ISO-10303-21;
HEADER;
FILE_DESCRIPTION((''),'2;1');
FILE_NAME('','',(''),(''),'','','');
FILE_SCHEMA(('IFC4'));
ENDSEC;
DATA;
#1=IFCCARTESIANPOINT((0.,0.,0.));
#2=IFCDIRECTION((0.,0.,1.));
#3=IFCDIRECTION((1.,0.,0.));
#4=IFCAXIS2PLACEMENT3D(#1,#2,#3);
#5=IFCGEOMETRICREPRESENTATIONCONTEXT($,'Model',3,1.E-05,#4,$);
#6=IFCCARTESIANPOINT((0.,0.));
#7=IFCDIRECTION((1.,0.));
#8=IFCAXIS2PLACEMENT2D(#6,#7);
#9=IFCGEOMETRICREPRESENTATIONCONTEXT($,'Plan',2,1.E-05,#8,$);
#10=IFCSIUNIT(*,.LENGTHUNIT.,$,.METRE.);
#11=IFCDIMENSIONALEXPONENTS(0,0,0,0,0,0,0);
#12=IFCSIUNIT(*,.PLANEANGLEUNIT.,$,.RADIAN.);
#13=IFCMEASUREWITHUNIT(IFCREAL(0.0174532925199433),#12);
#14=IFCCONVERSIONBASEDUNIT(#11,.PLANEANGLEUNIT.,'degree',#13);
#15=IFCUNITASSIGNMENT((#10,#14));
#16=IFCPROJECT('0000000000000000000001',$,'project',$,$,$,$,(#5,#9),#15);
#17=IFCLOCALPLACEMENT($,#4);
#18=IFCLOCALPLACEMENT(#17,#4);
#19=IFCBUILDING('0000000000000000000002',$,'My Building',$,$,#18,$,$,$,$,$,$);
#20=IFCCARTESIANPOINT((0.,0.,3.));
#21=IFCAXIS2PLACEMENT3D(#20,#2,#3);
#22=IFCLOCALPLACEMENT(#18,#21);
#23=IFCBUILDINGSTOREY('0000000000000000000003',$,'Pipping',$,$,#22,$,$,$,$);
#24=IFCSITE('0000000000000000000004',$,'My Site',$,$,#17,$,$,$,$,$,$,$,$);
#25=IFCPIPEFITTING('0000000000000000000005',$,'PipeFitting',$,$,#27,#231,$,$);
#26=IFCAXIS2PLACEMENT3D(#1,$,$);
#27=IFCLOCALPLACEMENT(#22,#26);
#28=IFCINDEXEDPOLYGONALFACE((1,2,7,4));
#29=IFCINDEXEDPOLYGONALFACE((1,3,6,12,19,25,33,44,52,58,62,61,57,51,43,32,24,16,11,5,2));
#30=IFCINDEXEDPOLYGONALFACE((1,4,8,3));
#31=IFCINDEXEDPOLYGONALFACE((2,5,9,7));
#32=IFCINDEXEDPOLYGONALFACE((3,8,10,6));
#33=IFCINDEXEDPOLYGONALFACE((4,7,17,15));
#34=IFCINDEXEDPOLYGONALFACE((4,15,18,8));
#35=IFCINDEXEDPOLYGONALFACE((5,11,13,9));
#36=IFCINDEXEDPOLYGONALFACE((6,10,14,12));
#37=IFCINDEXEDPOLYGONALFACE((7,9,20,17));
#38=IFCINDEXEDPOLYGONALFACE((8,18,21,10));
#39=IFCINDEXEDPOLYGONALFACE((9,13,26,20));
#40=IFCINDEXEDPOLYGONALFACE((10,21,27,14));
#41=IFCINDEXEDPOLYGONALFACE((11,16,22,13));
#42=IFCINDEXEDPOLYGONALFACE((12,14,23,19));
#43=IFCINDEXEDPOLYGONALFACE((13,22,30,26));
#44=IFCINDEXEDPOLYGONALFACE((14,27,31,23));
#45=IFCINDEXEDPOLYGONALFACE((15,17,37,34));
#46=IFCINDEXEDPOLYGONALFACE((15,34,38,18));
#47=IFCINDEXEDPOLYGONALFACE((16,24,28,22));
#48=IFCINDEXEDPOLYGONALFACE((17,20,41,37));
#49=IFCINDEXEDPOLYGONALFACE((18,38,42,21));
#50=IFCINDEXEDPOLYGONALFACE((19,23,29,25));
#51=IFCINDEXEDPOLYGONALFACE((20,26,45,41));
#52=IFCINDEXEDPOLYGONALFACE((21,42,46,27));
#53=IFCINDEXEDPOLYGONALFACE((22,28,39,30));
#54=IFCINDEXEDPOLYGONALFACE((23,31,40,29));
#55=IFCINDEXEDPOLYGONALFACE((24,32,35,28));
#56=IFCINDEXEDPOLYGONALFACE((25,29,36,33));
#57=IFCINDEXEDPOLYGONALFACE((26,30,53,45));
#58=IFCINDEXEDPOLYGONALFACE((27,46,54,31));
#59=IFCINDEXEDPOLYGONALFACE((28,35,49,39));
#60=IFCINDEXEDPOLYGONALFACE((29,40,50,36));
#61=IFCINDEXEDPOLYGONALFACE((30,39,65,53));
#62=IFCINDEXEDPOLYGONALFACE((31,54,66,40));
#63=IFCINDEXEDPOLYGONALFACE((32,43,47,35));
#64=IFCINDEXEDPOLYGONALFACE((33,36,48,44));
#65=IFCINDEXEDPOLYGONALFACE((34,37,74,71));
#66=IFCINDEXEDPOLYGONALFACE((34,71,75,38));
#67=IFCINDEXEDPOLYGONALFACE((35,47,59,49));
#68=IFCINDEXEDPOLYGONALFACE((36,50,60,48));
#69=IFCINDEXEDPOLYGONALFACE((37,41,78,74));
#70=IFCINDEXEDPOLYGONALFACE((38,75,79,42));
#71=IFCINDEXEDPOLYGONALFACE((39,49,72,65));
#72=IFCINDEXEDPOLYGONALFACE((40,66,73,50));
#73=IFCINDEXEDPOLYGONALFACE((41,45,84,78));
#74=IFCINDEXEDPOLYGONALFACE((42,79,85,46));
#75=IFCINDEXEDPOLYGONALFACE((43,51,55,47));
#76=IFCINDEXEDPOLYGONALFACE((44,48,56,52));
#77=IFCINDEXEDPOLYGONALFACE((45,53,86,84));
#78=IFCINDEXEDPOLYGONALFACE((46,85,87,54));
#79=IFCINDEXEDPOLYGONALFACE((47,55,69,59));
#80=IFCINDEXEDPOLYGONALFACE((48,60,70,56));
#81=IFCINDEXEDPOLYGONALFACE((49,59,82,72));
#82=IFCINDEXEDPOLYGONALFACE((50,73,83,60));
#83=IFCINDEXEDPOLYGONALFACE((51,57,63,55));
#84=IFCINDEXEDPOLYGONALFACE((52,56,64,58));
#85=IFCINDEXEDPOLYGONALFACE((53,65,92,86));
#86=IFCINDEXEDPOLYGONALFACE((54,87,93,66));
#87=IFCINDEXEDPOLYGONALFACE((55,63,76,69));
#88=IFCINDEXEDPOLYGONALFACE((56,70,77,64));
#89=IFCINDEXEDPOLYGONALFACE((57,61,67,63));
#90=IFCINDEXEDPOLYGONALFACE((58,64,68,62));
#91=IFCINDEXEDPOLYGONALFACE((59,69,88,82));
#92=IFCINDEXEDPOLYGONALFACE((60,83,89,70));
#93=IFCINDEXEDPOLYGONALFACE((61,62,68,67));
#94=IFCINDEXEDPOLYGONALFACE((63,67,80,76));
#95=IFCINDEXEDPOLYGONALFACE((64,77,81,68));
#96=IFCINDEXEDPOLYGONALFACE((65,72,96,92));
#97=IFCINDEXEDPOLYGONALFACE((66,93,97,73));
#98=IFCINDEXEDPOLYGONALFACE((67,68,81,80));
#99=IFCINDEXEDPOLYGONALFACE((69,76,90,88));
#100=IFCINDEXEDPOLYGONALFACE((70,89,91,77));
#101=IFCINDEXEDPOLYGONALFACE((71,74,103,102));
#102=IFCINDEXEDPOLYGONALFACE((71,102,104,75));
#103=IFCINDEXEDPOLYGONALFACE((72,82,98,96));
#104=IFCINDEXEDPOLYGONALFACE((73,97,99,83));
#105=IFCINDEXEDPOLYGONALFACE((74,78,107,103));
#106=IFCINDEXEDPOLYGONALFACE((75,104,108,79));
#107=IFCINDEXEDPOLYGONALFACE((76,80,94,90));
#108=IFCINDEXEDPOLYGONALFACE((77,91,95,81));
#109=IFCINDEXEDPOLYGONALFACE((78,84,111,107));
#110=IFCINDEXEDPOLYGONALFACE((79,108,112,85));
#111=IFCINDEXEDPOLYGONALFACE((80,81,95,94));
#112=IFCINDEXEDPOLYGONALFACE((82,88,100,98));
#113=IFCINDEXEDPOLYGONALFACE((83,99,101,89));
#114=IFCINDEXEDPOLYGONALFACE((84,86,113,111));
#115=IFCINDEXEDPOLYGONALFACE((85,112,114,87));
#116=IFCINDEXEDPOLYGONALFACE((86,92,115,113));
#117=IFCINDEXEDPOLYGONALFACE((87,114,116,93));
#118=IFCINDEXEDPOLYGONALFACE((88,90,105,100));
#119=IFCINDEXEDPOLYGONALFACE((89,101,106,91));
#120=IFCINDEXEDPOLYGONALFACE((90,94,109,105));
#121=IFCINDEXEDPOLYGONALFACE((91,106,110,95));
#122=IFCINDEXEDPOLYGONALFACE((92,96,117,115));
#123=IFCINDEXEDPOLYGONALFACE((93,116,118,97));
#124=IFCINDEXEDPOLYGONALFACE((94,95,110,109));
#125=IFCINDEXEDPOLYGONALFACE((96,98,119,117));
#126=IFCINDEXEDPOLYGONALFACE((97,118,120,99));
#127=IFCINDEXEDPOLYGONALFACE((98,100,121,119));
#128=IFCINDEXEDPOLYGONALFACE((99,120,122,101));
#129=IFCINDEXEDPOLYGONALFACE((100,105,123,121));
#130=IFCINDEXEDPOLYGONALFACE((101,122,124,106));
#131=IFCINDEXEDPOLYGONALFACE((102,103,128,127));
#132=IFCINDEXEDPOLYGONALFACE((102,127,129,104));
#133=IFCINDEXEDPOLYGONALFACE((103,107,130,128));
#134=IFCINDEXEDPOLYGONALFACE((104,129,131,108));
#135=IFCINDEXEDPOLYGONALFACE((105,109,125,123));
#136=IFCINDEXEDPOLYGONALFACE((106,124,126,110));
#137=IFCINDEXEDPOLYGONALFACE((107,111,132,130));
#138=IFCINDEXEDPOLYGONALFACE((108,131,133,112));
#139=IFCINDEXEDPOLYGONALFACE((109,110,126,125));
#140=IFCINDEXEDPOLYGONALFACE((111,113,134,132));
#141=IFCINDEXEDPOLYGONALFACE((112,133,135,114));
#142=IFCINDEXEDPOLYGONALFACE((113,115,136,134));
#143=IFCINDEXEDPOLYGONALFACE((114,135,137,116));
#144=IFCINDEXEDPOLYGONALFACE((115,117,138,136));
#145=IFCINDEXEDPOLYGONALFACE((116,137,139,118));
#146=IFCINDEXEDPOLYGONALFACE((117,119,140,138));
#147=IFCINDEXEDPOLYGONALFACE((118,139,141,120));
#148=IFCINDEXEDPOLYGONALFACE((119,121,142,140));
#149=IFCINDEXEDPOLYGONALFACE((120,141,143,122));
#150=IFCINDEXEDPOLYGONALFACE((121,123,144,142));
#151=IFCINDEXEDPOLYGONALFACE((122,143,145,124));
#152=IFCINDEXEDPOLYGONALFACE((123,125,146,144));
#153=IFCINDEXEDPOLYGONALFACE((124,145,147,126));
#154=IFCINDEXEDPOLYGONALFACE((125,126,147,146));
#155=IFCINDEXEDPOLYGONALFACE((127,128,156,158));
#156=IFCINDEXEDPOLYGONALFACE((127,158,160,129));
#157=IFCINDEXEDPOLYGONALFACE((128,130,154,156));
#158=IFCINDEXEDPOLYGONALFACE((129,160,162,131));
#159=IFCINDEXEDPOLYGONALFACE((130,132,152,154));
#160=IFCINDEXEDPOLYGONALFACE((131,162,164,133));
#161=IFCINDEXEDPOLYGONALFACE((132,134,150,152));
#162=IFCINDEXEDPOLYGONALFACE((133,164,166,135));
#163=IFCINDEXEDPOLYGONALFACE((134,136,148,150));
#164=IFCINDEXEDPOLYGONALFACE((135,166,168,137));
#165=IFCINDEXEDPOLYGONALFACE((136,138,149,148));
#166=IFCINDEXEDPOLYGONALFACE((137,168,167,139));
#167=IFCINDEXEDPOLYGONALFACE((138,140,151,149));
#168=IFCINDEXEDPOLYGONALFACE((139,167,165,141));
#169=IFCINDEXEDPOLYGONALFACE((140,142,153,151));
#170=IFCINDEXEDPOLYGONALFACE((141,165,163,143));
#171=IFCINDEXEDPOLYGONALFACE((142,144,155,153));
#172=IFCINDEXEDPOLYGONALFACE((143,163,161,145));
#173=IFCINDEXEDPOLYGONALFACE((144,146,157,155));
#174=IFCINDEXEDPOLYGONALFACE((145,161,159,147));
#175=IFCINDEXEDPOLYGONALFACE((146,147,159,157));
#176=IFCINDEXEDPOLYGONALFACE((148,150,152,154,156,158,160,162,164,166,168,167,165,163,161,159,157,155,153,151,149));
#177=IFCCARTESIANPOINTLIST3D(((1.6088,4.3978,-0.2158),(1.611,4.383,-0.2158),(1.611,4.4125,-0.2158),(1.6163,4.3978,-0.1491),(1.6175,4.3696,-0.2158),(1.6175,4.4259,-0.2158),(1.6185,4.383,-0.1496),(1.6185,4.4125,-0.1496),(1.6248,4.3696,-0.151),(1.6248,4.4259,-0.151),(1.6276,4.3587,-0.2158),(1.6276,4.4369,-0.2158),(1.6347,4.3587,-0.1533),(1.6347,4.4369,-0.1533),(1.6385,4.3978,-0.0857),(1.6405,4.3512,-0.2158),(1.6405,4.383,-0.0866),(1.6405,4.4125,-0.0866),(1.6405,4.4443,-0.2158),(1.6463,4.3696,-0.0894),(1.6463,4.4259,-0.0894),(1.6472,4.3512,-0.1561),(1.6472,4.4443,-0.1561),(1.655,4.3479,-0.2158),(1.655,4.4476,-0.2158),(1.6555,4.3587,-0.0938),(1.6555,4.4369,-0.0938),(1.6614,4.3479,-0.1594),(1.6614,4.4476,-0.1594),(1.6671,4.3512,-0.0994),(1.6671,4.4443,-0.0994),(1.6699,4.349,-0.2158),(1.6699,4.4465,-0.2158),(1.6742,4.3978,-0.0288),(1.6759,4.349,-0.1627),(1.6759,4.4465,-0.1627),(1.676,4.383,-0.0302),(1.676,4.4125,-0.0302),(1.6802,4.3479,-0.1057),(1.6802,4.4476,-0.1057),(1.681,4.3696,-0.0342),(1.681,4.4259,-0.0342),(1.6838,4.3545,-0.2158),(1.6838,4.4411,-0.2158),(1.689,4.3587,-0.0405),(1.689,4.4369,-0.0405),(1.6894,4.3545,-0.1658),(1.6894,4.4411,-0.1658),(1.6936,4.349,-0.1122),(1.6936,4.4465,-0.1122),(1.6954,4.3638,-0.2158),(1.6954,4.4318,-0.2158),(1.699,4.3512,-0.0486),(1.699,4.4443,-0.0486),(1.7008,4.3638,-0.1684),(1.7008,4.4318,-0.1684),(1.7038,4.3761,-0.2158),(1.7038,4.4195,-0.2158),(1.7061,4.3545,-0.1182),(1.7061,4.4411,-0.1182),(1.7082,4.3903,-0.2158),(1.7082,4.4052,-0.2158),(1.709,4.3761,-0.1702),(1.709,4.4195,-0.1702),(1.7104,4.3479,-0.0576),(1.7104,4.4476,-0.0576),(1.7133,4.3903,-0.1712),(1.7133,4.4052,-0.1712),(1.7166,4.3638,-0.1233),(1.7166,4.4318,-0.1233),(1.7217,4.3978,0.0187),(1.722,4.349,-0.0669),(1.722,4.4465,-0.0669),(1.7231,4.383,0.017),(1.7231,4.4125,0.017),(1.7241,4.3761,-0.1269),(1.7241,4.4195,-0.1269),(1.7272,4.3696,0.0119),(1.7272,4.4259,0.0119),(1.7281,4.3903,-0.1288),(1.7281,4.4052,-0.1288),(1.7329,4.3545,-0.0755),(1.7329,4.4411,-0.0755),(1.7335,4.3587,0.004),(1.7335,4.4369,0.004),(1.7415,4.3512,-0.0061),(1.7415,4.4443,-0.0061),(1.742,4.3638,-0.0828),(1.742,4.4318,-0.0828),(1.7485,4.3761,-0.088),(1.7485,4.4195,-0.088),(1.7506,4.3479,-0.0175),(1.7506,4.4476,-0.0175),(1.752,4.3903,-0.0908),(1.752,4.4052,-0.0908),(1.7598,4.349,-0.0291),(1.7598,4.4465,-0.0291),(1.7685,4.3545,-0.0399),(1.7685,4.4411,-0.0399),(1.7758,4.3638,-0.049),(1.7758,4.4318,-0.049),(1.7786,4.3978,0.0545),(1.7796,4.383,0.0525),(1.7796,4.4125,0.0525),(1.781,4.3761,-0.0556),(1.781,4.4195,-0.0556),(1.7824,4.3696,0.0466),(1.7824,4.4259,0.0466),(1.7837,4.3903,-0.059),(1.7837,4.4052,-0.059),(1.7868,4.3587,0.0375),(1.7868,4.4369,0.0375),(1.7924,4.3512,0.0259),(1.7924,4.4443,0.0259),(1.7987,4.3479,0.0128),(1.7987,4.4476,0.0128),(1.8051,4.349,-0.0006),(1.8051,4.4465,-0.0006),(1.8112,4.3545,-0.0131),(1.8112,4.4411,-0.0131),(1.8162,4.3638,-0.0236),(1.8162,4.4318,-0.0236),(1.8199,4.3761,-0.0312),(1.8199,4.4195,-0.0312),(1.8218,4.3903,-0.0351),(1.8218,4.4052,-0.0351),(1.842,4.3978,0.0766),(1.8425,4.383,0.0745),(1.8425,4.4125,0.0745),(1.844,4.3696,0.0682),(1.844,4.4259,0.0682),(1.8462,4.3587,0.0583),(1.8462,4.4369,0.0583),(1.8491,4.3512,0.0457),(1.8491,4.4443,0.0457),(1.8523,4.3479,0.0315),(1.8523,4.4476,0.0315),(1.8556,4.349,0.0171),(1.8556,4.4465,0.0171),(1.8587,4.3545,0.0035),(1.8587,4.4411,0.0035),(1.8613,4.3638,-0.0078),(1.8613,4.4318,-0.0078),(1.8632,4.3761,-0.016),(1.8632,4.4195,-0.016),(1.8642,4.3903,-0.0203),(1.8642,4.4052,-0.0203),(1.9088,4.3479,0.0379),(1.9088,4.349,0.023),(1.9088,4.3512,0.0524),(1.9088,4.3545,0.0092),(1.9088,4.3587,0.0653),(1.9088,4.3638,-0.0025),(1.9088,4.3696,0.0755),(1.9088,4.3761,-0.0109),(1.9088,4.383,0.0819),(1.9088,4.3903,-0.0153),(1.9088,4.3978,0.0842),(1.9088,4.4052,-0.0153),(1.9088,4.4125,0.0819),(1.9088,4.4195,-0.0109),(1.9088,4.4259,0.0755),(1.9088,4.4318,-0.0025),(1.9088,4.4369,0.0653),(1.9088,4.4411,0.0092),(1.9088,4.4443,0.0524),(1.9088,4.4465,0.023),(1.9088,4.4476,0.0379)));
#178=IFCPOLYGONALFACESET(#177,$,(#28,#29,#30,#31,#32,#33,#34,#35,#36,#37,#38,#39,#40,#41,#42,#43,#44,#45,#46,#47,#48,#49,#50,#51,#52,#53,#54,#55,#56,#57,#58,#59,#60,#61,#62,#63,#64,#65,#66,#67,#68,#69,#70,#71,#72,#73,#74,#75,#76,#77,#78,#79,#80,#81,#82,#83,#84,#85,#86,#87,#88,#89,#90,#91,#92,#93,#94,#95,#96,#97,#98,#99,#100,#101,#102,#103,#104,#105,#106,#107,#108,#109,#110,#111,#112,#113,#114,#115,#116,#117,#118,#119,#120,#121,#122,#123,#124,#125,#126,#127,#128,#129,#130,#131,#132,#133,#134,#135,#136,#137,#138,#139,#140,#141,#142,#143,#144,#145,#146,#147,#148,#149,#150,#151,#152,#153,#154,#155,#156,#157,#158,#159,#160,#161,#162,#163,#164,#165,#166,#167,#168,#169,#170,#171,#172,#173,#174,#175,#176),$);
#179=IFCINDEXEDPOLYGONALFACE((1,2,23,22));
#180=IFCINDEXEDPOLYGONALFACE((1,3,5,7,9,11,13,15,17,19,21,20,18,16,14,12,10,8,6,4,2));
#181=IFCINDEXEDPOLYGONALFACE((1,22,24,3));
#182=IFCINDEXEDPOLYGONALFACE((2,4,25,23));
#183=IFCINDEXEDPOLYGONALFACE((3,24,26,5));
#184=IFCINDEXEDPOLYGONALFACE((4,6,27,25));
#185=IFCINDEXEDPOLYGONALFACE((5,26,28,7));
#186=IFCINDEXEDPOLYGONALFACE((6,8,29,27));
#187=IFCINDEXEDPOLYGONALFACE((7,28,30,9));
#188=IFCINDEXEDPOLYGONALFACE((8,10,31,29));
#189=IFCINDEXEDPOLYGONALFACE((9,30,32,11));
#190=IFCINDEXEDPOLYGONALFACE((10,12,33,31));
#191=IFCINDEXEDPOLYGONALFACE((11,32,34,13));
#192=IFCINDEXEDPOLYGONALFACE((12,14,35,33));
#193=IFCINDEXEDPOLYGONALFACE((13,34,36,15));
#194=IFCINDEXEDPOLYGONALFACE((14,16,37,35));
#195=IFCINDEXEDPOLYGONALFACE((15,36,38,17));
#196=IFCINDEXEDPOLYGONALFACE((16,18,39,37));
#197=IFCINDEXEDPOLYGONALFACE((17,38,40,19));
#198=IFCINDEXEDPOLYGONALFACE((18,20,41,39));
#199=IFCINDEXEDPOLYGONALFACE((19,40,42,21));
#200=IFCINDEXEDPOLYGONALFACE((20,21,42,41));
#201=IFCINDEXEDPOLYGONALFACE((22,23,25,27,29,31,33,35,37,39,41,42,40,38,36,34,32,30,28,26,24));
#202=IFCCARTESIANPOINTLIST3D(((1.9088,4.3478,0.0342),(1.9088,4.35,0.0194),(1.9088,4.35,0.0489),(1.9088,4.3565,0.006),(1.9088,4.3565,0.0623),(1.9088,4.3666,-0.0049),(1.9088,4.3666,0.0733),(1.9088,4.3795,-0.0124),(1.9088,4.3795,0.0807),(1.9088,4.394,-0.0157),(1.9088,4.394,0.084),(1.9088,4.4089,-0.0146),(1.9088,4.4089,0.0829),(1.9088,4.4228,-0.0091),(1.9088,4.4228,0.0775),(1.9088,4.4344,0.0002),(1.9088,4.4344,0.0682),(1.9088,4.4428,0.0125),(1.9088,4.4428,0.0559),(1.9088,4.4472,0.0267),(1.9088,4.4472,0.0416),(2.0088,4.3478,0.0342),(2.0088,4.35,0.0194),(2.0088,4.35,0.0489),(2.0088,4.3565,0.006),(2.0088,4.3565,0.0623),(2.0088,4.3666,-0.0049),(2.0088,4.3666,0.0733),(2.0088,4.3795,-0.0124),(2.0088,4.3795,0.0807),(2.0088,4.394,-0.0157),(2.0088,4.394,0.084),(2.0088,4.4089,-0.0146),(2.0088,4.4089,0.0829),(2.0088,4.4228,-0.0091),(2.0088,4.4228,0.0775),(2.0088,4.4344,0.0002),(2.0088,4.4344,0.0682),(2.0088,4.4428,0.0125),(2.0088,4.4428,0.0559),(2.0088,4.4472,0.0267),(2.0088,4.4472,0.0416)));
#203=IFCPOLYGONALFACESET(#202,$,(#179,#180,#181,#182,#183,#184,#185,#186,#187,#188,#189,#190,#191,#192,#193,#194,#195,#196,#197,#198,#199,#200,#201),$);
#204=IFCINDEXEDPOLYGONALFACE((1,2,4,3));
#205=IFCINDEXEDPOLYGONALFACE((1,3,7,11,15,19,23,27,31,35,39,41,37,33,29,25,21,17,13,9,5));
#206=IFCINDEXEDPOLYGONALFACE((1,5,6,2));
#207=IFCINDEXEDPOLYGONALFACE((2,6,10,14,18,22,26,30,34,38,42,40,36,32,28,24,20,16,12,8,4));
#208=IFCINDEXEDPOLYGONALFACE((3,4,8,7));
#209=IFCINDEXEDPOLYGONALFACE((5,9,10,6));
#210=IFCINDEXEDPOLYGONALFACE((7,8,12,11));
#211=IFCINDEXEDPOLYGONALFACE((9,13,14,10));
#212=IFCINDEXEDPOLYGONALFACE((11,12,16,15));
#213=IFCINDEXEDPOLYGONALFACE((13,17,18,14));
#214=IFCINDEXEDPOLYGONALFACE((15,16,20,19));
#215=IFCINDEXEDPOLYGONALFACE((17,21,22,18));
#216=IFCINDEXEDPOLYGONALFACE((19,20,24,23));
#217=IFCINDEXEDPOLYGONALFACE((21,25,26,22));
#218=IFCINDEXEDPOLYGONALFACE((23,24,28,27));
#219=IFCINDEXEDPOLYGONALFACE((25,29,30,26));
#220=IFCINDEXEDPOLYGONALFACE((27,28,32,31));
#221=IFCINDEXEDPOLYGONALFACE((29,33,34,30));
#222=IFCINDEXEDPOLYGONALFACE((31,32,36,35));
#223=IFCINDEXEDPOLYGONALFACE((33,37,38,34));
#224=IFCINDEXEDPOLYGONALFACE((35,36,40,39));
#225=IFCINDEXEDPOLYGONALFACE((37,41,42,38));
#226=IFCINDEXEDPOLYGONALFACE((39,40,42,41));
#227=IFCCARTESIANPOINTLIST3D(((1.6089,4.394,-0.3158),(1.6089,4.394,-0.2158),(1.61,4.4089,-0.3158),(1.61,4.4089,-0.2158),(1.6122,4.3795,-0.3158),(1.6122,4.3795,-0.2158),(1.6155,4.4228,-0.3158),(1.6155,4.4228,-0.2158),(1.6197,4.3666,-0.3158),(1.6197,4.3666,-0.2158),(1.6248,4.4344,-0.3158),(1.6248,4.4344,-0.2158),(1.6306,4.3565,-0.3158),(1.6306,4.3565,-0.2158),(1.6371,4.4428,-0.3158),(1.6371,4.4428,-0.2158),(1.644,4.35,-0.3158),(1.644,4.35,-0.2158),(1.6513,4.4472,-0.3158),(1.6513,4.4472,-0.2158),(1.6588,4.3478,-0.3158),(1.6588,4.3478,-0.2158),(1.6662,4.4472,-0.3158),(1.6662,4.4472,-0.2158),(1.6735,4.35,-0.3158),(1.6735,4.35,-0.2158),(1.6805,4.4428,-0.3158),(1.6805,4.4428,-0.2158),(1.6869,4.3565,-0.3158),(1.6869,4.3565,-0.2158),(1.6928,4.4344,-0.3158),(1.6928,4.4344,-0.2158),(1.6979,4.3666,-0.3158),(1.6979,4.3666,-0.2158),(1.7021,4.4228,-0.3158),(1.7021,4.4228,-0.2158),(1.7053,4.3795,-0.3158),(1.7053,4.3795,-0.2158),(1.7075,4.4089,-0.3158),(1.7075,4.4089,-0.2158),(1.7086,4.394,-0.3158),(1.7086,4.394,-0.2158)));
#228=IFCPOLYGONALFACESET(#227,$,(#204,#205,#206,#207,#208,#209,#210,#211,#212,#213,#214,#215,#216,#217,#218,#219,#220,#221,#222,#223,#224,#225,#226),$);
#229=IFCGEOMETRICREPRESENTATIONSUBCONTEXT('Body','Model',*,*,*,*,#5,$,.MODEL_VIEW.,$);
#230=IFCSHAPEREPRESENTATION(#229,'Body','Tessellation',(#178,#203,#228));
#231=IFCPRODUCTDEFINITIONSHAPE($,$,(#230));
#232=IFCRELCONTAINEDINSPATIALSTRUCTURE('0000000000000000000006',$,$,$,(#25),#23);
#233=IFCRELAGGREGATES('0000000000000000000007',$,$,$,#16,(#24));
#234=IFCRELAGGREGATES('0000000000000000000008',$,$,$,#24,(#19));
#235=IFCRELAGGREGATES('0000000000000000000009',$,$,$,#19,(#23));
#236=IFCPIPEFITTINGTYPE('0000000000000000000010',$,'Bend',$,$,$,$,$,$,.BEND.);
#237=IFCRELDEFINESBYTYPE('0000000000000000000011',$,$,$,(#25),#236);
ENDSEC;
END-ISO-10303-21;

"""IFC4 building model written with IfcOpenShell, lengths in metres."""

from ifc_helpers import new_model, entity, si_unit, converted_unit, frame, origin_with_axes, origin_2d_with_axis, place, context, subcontext, project, spatial, circle, extrude, source, transform, mapped, type_object, type_shapes, element, save


model = new_model("IFC4")

# Units and contexts
model_context = context("Model", 3, precision=1e-05, world=origin_with_axes())
plan_context = context("Plan", 2, precision=1e-05, world=origin_2d_with_axis())
body_context = subcontext(model_context, "Body", "Model", "MODEL_VIEW")
ifc_project = project(units=[si_unit("LENGTHUNIT", "METRE"), converted_unit("PLANEANGLEUNIT", "degree", entity("IfcReal", 0.0174532925199433), si_unit("PLANEANGLEUNIT", "RADIAN"), dimensions=[0, 0, 0, 0, 0, 0, 0])], contexts=[model_context, plan_context])

# Site, building, storey
site_placement = place(None, origin_with_axes())
site = spatial("IfcSite", under=ifc_project, at=site_placement, Name="My Site")
building_placement = place(site_placement, origin_with_axes())
building = spatial("IfcBuilding", under=site, at=building_placement, Name="My Building")
storey_placement = place(building_placement, frame((0.0, 0.0, 3.0), z_axis=(0.0, 0.0, 1.0), x_axis=(1.0, 0.0, 0.0)))
storey = spatial("IfcBuildingStorey", under=building, at=storey_placement, Name="Pipping")

# Pipe fitting
pipe_fitting_type_1 = type_object("IfcPipeFittingType", Name="Bend", PredefinedType="BEND")
shared_shape_1 = source(origin_with_axes(), body_context, "Body", "SolidModel", [
    entity("IfcSweptDiskSolid", entity("IfcIndexedPolyCurve", entity("IfcCartesianPointList3D", [[0.0, 0.0, 0.1], [0.0, -0.0732, 0.2768], [0.0, -0.25, 0.35]]), [entity("IfcArcIndex", [1, 2, 3])]), 0.05),
    extrude(circle(Radius=0.05), origin_with_axes(), (0.0, 0.0, 1.0), 0.1),
    extrude(circle(Radius=0.05), frame((0.0, -0.25, 0.35), z_axis=(0.0, -1.0, 0.0), x_axis=(1.0, 0.0, 0.0)), (0.0, 0.0, 1.0), 0.1),
])
type_shapes(pipe_fitting_type_1, [shared_shape_1])
for number, where, z_axis, x_axis, name in (
    (1, (2.0088, 4.3978, 0.0342), (-1.0, 0.0, 0.0), (0.0, -1.0, 0.0), "PipeFitting"),
):
    element("IfcPipeFitting", number, at=place(storey_placement, frame(where, z_axis=z_axis, x_axis=x_axis)), inside=storey, type_object=pipe_fitting_type_1, Name=name, context=body_context, shape_type="MappedRepresentation", body=[
        mapped(shared_shape_1, transform((0.0, 0.0, 0.0), x_axis=(1.0, 0.0, 0.0), y_axis=(0.0, 1.0, 0.0), z_axis=(0.0, 0.0, 1.0), scale=1.0)),
    ])

save(model, "model.ifc")
